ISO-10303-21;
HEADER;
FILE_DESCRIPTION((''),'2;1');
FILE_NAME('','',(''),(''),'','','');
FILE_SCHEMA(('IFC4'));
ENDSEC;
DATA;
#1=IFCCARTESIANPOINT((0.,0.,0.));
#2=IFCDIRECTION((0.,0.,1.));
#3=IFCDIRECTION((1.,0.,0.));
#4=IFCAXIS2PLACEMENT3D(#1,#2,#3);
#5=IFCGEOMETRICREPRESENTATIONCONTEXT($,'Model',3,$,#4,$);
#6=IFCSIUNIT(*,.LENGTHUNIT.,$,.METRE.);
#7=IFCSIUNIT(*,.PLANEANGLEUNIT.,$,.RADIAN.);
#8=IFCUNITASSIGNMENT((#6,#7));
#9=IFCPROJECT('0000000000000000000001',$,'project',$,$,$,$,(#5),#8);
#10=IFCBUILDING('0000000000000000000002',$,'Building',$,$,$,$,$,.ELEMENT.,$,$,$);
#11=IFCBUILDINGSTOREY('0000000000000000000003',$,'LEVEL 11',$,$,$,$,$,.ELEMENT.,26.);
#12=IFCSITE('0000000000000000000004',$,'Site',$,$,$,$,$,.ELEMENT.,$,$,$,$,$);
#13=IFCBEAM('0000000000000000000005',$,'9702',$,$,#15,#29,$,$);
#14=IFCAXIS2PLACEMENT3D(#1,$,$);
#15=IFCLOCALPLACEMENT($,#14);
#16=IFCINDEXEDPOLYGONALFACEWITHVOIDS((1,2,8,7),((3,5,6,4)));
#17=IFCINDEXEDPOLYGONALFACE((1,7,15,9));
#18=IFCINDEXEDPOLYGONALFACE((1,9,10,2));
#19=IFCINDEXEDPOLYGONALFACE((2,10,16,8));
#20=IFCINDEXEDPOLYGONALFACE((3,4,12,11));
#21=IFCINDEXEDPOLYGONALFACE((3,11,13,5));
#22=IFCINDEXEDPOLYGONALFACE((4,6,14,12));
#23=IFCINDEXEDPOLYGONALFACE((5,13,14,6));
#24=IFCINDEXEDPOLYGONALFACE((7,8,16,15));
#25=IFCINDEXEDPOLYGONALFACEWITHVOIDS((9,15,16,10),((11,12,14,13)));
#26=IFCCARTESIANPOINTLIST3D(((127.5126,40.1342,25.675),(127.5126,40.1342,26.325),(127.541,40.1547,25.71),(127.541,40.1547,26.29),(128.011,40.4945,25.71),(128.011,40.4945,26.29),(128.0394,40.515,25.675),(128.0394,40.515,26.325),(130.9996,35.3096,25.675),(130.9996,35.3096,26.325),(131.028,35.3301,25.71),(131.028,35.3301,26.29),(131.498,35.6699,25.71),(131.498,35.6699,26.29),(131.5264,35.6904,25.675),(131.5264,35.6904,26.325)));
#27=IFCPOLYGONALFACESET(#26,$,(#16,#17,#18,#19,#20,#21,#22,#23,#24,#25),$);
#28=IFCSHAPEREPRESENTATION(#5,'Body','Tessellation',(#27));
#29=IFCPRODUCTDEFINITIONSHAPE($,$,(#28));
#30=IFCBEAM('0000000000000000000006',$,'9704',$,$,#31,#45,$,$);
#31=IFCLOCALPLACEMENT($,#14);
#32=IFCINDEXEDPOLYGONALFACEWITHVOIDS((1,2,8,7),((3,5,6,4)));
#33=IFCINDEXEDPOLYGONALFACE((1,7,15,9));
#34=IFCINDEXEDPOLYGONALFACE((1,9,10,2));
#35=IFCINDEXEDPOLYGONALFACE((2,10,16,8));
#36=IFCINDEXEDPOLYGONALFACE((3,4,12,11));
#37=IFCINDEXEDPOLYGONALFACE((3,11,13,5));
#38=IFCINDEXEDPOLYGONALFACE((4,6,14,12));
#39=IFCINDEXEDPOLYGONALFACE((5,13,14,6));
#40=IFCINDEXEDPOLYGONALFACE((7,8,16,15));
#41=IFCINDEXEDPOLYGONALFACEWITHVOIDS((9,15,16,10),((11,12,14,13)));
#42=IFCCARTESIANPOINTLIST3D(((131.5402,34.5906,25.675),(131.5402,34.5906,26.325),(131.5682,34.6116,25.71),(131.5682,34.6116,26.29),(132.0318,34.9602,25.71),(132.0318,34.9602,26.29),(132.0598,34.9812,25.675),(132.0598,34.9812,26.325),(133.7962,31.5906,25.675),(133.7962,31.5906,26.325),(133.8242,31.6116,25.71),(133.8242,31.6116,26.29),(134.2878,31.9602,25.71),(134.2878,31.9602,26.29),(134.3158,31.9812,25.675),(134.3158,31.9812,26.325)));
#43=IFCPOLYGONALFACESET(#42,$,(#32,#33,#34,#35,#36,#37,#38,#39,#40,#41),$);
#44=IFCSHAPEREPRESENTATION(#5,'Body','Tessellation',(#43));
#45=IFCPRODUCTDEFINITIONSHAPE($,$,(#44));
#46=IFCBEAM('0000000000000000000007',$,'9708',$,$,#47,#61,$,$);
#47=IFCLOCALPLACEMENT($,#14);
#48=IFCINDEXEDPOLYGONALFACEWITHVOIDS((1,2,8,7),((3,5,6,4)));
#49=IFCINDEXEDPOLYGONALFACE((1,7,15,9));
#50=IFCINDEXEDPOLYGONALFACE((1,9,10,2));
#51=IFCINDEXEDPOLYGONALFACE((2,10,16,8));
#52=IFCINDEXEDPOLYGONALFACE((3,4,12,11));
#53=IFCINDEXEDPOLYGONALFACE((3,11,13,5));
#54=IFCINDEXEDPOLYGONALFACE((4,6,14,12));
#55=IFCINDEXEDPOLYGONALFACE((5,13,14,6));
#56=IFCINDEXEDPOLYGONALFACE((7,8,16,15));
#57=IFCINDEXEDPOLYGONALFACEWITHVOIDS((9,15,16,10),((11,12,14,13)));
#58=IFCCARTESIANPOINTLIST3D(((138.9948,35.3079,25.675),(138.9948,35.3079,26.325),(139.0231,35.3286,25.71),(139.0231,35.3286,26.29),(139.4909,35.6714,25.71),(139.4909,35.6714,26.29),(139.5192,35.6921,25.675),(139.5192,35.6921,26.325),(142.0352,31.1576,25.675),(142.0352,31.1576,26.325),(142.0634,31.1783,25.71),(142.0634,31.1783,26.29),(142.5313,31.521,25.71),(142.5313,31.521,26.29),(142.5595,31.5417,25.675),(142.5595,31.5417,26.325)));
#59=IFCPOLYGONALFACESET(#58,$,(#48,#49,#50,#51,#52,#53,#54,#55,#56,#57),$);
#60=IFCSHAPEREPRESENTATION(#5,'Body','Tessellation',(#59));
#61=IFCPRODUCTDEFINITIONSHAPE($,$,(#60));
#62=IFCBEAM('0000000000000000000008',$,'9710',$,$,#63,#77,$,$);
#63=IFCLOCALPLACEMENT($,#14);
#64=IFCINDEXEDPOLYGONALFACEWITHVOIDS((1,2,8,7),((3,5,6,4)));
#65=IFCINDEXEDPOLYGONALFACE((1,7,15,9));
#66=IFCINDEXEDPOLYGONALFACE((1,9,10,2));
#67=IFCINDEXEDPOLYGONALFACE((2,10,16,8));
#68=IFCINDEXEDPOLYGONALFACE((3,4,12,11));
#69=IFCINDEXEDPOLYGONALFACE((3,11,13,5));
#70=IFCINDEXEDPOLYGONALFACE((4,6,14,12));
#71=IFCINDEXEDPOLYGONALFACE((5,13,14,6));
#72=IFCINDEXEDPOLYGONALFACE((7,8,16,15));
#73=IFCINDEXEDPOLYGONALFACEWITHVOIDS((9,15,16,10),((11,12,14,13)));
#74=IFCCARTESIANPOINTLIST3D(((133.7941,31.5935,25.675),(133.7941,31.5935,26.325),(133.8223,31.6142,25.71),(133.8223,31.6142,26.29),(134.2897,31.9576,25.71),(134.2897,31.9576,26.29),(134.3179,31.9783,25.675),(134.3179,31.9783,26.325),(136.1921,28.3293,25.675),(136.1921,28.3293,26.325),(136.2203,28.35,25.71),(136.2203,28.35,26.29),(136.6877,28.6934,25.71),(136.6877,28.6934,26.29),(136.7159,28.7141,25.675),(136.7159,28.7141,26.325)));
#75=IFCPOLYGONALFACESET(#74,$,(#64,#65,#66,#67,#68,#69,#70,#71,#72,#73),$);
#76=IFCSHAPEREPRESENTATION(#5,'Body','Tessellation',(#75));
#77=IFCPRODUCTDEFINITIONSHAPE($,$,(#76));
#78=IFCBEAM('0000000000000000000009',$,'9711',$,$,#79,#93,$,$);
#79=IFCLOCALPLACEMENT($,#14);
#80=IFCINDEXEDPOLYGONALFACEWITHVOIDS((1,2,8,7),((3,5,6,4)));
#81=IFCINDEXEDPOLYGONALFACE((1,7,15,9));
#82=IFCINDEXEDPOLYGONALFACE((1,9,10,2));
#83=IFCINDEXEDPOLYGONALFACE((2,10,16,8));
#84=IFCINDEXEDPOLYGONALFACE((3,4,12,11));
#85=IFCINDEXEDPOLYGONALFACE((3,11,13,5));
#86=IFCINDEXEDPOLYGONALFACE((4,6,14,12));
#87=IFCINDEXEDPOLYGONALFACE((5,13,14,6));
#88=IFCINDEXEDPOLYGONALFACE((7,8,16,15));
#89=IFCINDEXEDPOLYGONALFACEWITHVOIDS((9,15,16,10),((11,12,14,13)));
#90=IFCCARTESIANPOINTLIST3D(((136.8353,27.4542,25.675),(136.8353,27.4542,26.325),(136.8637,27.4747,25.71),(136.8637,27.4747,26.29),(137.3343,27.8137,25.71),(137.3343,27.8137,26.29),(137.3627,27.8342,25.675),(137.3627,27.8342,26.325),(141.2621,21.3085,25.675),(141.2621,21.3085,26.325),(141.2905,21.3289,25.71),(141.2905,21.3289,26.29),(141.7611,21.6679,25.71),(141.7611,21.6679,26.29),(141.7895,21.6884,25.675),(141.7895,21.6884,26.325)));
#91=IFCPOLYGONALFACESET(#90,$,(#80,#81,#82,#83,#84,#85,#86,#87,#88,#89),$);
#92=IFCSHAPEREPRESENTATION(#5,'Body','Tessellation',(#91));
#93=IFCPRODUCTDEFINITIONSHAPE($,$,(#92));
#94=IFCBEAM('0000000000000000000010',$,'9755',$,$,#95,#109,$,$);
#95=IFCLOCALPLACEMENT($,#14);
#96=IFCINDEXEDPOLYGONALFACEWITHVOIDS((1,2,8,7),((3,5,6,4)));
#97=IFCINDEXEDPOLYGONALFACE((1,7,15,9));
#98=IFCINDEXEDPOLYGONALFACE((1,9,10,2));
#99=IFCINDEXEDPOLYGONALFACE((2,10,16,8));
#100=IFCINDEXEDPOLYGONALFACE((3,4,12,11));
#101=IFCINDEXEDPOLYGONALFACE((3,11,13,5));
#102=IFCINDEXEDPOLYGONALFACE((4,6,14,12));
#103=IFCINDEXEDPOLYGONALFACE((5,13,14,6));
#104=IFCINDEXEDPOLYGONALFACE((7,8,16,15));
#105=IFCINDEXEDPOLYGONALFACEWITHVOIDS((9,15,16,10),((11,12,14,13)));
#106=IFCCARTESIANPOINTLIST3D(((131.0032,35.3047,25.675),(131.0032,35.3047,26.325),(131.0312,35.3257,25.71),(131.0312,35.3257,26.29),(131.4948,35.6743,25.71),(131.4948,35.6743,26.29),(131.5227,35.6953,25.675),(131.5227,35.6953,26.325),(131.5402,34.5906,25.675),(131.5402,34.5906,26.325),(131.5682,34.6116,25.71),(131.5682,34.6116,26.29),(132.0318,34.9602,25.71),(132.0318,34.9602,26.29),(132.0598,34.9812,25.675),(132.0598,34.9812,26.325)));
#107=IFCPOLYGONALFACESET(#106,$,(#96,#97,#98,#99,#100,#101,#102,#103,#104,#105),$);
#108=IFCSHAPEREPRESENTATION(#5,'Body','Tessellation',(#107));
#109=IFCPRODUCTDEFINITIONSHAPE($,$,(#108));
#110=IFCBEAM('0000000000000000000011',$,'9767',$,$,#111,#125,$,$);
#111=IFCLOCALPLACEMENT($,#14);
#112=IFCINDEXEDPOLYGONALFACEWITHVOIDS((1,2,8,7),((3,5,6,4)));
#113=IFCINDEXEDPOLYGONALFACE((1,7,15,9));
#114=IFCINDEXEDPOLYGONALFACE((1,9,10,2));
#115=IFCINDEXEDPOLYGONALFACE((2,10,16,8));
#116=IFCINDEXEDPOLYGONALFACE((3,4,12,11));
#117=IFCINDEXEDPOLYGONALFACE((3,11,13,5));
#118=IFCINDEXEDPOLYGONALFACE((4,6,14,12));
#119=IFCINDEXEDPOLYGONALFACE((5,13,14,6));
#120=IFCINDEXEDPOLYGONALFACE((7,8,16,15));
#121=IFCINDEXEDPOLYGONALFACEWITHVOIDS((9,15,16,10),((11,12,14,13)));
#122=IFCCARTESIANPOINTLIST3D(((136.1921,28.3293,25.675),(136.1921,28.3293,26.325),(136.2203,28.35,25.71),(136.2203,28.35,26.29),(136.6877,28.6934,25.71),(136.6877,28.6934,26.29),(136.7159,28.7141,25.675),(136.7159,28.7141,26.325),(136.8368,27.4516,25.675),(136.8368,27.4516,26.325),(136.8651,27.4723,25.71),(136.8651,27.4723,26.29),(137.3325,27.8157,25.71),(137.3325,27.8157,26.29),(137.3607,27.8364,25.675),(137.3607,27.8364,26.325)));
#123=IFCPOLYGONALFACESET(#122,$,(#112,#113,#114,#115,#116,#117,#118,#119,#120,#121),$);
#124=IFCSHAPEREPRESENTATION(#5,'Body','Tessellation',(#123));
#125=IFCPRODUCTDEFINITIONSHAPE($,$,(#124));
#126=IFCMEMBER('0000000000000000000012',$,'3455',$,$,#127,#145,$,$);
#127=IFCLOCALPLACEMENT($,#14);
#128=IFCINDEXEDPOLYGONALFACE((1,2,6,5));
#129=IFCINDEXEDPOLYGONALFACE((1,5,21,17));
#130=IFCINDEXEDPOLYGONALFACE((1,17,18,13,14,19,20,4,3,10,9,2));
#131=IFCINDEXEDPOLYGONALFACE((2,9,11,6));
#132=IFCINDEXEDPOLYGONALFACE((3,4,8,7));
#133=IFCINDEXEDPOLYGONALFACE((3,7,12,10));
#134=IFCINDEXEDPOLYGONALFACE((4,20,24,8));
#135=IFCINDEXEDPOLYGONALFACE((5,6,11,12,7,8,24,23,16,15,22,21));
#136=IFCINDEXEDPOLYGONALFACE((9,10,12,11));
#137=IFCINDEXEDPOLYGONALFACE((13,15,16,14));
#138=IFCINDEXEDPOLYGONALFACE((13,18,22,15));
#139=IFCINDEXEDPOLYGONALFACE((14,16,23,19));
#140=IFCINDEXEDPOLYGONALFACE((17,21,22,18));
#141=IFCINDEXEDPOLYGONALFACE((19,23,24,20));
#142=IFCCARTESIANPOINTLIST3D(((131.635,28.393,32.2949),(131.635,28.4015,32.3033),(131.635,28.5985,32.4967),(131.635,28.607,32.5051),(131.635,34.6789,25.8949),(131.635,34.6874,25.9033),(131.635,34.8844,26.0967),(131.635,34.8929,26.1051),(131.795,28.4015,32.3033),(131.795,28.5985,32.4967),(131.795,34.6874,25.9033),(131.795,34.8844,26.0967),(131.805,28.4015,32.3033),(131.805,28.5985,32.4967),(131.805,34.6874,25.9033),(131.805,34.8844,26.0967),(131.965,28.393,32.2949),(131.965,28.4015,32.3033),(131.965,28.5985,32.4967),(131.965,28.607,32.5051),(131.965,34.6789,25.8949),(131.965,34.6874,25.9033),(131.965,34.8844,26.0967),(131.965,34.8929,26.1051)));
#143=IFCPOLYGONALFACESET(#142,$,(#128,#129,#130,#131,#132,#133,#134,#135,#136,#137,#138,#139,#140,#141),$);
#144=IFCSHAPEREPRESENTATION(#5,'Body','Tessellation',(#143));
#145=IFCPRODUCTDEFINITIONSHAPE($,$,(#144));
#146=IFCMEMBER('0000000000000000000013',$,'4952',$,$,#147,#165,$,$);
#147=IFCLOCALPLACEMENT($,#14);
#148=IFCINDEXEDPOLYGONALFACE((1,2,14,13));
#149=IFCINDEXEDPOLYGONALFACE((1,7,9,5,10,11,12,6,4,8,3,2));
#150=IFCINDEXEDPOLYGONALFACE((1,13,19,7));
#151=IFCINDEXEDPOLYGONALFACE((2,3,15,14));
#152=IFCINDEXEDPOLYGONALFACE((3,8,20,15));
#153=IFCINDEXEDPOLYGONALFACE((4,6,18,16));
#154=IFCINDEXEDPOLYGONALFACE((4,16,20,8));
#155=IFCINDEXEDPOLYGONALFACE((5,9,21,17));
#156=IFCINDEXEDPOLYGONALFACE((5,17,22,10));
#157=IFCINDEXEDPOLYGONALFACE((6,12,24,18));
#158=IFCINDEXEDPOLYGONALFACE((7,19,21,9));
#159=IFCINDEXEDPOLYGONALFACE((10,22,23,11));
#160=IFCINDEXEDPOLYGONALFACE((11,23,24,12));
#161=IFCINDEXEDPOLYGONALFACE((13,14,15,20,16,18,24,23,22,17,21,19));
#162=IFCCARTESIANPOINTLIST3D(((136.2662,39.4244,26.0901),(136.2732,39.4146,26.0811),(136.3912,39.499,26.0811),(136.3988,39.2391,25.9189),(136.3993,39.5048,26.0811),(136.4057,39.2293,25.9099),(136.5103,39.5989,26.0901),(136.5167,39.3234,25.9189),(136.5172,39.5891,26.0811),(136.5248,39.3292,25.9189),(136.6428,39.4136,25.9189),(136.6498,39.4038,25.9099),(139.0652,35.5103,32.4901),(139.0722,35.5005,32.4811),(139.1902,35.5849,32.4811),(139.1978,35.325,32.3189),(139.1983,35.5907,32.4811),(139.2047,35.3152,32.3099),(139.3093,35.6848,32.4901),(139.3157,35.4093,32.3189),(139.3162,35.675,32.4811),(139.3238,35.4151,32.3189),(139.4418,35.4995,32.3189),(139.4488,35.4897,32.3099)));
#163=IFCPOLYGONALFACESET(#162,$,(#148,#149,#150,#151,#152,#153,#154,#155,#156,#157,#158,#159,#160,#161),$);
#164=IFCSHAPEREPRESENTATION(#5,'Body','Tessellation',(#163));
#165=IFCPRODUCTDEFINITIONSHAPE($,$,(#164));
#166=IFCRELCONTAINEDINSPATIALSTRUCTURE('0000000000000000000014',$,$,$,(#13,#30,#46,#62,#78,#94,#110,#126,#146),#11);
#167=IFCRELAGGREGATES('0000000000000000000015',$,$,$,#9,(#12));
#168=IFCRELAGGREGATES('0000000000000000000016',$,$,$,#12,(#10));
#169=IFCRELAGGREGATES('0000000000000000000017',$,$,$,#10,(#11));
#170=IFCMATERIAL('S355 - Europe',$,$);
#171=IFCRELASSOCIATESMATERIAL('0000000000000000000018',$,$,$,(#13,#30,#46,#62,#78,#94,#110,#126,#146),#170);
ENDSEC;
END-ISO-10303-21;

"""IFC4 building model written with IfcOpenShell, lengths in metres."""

from ifc_helpers import new_model, si_unit, frame, origin_with_axes, origin_2d_with_axis, place, context, project, spatial, hollow_rectangle, i_section, extrude, material, material_profile, profile_set, profile_usage, element, save


model = new_model("IFC4")

# Units and contexts
model_context = context("Model", 3, world=origin_with_axes())
ifc_project = project(units=[si_unit("LENGTHUNIT", "METRE"), si_unit("PLANEANGLEUNIT", "RADIAN")], contexts=[model_context])

# Site, building, storey
site = spatial("IfcSite", under=ifc_project, Name="Site", CompositionType="ELEMENT")
building = spatial("IfcBuilding", under=site, Name="Building", CompositionType="ELEMENT")
storey = spatial("IfcBuildingStorey", under=building, Name="LEVEL 11", CompositionType="ELEMENT", Elevation=26.0)

# Shared definitions
ifc_material = material(Name="S355 - Europe")

# Beams
ifc_material_profile_1 = material_profile(ifc_material, hollow_rectangle(XDim=0.65, YDim=0.65, WallThickness=0.035, at=origin_2d_with_axis()))
ifc_profile_set_1 = profile_set([ifc_material_profile_1])
ifc_profile_usage_1 = profile_usage(ifc_profile_set_1, cardinal=10)
beam_1_placement = place(None, frame((131.263, 35.5, 26.0), z_axis=(-0.585773, 0.810475, 0.0), x_axis=(-0.810441, -0.585821, 0.0)))
element("IfcBeam", 1, at=beam_1_placement, inside=storey, material=ifc_profile_usage_1, Name="9702", context=model_context, shape_type="SweptSolid", body=[
    extrude(hollow_rectangle(XDim=0.65, YDim=0.65, WallThickness=0.035, at=origin_2d_with_axis()), origin_with_axes(), (0.0, 0.0, 1.0), 5.9528),
])
ifc_material_profile_2 = material_profile(ifc_material, hollow_rectangle(XDim=0.65, YDim=0.65, WallThickness=0.035, at=origin_2d_with_axis()))
ifc_profile_set_2 = profile_set([ifc_material_profile_2])
ifc_profile_usage_2 = profile_usage(ifc_profile_set_2, cardinal=10)
beam_2_placement = place(None, frame((134.056, 31.7859, 26.0), z_axis=(-0.601023, 0.799232, 0.0), x_axis=(-0.799232, -0.601023, 0.0)))
element("IfcBeam", 2, at=beam_2_placement, inside=storey, material=ifc_profile_usage_2, Name="9704", context=model_context, shape_type="SweptSolid", body=[
    extrude(hollow_rectangle(XDim=0.65, YDim=0.65, WallThickness=0.035, at=origin_2d_with_axis()), origin_with_axes(), (0.0, 0.0, 1.0), 3.7536),
])
ifc_material_profile_3 = material_profile(ifc_material, hollow_rectangle(XDim=0.65, YDim=0.65, WallThickness=0.035, at=origin_2d_with_axis()))
ifc_profile_set_3 = profile_set([ifc_material_profile_3])
ifc_profile_usage_3 = profile_usage(ifc_profile_set_3, cardinal=10)
beam_3_placement = place(None, frame((139.257, 35.5, 26.0), z_axis=(0.590953, -0.806706, 0.0), x_axis=(0.806353, 0.591435, 0.0)))
element("IfcBeam", 3, at=beam_3_placement, inside=storey, material=ifc_profile_usage_3, Name="9708", context=model_context, shape_type="SweptSolid", body=[
    extrude(hollow_rectangle(XDim=0.65, YDim=0.65, WallThickness=0.035, at=origin_2d_with_axis()), origin_with_axes(), (0.0, 0.0, 1.0), 5.1448),
])
ifc_material_profile_4 = material_profile(ifc_material, hollow_rectangle(XDim=0.65, YDim=0.65, WallThickness=0.035, at=origin_2d_with_axis()))
ifc_profile_set_4 = profile_set([ifc_material_profile_4])
ifc_profile_usage_4 = profile_usage(ifc_profile_set_4, cardinal=10)
beam_4_placement = place(None, frame((134.056, 31.7859, 26.0), z_axis=(0.592045, -0.805905, 0.0), x_axis=(0.805798, 0.59219, 0.0)))
element("IfcBeam", 4, at=beam_4_placement, inside=storey, material=ifc_profile_usage_4, Name="9710", context=model_context, shape_type="SweptSolid", body=[
    extrude(hollow_rectangle(XDim=0.65, YDim=0.65, WallThickness=0.035, at=origin_2d_with_axis()), origin_with_axes(), (0.0, 0.0, 1.0), 4.0504),
])
ifc_material_profile_5 = material_profile(ifc_material, hollow_rectangle(XDim=0.65, YDim=0.65, WallThickness=0.035, at=origin_2d_with_axis()))
ifc_profile_set_5 = profile_set([ifc_material_profile_5])
ifc_profile_usage_5 = profile_usage(ifc_profile_set_5, cardinal=10)
beam_5_placement = place(None, frame((137.099, 27.6442, 26.0), z_axis=(0.584465, -0.811419, 0.0), x_axis=(0.811419, 0.584465, 0.0)))
element("IfcBeam", 5, at=beam_5_placement, inside=storey, material=ifc_profile_usage_5, Name="9711", context=model_context, shape_type="SweptSolid", body=[
    extrude(hollow_rectangle(XDim=0.65, YDim=0.65, WallThickness=0.035, at=origin_2d_with_axis()), origin_with_axes(), (0.0, 0.0, 1.0), 7.5741),
])
ifc_material_profile_6 = material_profile(ifc_material, hollow_rectangle(XDim=0.65, YDim=0.65, WallThickness=0.035, at=origin_2d_with_axis()))
ifc_profile_set_6 = profile_set([ifc_material_profile_6])
ifc_profile_usage_6 = profile_usage(ifc_profile_set_6, cardinal=10)
beam_6_placement = place(None, frame((131.8, 34.7859, 26.0), z_axis=(-0.601023, 0.799232, 0.0), x_axis=(-0.799234, -0.60102, 0.0)))
element("IfcBeam", 6, at=beam_6_placement, inside=storey, material=ifc_profile_usage_6, Name="9755", context=model_context, shape_type="SweptSolid", body=[
    extrude(hollow_rectangle(XDim=0.65, YDim=0.65, WallThickness=0.035, at=origin_2d_with_axis()), origin_with_axes(), (0.0, 0.0, 1.0), 0.8935),
])
ifc_material_profile_7 = material_profile(ifc_material, hollow_rectangle(XDim=0.65, YDim=0.65, WallThickness=0.035, at=origin_2d_with_axis()))
ifc_profile_set_7 = profile_set([ifc_material_profile_7])
ifc_profile_usage_7 = profile_usage(ifc_profile_set_7, cardinal=10)
beam_7_placement = place(None, frame((136.454, 28.5217, 26.0), z_axis=(0.592045, -0.805905, 0.0), x_axis=(0.805056, 0.593199, 0.0)))
element("IfcBeam", 7, at=beam_7_placement, inside=storey, material=ifc_profile_usage_7, Name="9767", context=model_context, shape_type="SweptSolid", body=[
    extrude(hollow_rectangle(XDim=0.65, YDim=0.65, WallThickness=0.035, at=origin_2d_with_axis()), origin_with_axes(), (0.0, 0.0, 1.0), 1.0891),
])

# Members
ifc_material_profile_8 = material_profile(ifc_material, i_section(OverallWidth=0.33, OverallDepth=0.3, WebThickness=0.01, FlangeThickness=0.012, at=origin_2d_with_axis()))
ifc_profile_set_8 = profile_set([ifc_material_profile_8])
ifc_profile_usage_8 = profile_usage(ifc_profile_set_8, cardinal=10)
member_1_placement = place(None, frame((131.8, 34.7859, 26.0), z_axis=(0.0, -0.700719, 0.713438), x_axis=(1.0, 0.0, 0.0)))
element("IfcMember", 8, at=member_1_placement, inside=storey, material=ifc_profile_usage_8, Name="3455", context=model_context, shape_type="SweptSolid", body=[
    extrude(i_section(OverallWidth=0.33, OverallDepth=0.3, WebThickness=0.01, FlangeThickness=0.012, at=origin_2d_with_axis()), origin_with_axes(), (0.0, 0.0, 1.0), 8.9706),
])
ifc_material_profile_9 = material_profile(ifc_material, i_section(OverallWidth=0.3, OverallDepth=0.3, WebThickness=0.01, FlangeThickness=0.015, at=origin_2d_with_axis()))
ifc_profile_set_9 = profile_set([ifc_material_profile_9])
ifc_profile_usage_9 = profile_usage(ifc_profile_set_9, cardinal=10)
member_2_placement = place(None, frame((139.257, 35.5, 32.4), z_axis=(-0.349562, 0.488825, -0.799285), x_axis=(-0.813417, -0.58168, 0.0)))
element("IfcMember", 9, at=member_2_placement, inside=storey, material=ifc_profile_usage_9, Name="4952", context=model_context, shape_type="SweptSolid", body=[
    extrude(i_section(OverallWidth=0.3, OverallDepth=0.3, WebThickness=0.01, FlangeThickness=0.015, at=origin_2d_with_axis()), origin_with_axes(), (0.0, 0.0, 1.0), 8.0072),
])

save(model, "model.ifc")
